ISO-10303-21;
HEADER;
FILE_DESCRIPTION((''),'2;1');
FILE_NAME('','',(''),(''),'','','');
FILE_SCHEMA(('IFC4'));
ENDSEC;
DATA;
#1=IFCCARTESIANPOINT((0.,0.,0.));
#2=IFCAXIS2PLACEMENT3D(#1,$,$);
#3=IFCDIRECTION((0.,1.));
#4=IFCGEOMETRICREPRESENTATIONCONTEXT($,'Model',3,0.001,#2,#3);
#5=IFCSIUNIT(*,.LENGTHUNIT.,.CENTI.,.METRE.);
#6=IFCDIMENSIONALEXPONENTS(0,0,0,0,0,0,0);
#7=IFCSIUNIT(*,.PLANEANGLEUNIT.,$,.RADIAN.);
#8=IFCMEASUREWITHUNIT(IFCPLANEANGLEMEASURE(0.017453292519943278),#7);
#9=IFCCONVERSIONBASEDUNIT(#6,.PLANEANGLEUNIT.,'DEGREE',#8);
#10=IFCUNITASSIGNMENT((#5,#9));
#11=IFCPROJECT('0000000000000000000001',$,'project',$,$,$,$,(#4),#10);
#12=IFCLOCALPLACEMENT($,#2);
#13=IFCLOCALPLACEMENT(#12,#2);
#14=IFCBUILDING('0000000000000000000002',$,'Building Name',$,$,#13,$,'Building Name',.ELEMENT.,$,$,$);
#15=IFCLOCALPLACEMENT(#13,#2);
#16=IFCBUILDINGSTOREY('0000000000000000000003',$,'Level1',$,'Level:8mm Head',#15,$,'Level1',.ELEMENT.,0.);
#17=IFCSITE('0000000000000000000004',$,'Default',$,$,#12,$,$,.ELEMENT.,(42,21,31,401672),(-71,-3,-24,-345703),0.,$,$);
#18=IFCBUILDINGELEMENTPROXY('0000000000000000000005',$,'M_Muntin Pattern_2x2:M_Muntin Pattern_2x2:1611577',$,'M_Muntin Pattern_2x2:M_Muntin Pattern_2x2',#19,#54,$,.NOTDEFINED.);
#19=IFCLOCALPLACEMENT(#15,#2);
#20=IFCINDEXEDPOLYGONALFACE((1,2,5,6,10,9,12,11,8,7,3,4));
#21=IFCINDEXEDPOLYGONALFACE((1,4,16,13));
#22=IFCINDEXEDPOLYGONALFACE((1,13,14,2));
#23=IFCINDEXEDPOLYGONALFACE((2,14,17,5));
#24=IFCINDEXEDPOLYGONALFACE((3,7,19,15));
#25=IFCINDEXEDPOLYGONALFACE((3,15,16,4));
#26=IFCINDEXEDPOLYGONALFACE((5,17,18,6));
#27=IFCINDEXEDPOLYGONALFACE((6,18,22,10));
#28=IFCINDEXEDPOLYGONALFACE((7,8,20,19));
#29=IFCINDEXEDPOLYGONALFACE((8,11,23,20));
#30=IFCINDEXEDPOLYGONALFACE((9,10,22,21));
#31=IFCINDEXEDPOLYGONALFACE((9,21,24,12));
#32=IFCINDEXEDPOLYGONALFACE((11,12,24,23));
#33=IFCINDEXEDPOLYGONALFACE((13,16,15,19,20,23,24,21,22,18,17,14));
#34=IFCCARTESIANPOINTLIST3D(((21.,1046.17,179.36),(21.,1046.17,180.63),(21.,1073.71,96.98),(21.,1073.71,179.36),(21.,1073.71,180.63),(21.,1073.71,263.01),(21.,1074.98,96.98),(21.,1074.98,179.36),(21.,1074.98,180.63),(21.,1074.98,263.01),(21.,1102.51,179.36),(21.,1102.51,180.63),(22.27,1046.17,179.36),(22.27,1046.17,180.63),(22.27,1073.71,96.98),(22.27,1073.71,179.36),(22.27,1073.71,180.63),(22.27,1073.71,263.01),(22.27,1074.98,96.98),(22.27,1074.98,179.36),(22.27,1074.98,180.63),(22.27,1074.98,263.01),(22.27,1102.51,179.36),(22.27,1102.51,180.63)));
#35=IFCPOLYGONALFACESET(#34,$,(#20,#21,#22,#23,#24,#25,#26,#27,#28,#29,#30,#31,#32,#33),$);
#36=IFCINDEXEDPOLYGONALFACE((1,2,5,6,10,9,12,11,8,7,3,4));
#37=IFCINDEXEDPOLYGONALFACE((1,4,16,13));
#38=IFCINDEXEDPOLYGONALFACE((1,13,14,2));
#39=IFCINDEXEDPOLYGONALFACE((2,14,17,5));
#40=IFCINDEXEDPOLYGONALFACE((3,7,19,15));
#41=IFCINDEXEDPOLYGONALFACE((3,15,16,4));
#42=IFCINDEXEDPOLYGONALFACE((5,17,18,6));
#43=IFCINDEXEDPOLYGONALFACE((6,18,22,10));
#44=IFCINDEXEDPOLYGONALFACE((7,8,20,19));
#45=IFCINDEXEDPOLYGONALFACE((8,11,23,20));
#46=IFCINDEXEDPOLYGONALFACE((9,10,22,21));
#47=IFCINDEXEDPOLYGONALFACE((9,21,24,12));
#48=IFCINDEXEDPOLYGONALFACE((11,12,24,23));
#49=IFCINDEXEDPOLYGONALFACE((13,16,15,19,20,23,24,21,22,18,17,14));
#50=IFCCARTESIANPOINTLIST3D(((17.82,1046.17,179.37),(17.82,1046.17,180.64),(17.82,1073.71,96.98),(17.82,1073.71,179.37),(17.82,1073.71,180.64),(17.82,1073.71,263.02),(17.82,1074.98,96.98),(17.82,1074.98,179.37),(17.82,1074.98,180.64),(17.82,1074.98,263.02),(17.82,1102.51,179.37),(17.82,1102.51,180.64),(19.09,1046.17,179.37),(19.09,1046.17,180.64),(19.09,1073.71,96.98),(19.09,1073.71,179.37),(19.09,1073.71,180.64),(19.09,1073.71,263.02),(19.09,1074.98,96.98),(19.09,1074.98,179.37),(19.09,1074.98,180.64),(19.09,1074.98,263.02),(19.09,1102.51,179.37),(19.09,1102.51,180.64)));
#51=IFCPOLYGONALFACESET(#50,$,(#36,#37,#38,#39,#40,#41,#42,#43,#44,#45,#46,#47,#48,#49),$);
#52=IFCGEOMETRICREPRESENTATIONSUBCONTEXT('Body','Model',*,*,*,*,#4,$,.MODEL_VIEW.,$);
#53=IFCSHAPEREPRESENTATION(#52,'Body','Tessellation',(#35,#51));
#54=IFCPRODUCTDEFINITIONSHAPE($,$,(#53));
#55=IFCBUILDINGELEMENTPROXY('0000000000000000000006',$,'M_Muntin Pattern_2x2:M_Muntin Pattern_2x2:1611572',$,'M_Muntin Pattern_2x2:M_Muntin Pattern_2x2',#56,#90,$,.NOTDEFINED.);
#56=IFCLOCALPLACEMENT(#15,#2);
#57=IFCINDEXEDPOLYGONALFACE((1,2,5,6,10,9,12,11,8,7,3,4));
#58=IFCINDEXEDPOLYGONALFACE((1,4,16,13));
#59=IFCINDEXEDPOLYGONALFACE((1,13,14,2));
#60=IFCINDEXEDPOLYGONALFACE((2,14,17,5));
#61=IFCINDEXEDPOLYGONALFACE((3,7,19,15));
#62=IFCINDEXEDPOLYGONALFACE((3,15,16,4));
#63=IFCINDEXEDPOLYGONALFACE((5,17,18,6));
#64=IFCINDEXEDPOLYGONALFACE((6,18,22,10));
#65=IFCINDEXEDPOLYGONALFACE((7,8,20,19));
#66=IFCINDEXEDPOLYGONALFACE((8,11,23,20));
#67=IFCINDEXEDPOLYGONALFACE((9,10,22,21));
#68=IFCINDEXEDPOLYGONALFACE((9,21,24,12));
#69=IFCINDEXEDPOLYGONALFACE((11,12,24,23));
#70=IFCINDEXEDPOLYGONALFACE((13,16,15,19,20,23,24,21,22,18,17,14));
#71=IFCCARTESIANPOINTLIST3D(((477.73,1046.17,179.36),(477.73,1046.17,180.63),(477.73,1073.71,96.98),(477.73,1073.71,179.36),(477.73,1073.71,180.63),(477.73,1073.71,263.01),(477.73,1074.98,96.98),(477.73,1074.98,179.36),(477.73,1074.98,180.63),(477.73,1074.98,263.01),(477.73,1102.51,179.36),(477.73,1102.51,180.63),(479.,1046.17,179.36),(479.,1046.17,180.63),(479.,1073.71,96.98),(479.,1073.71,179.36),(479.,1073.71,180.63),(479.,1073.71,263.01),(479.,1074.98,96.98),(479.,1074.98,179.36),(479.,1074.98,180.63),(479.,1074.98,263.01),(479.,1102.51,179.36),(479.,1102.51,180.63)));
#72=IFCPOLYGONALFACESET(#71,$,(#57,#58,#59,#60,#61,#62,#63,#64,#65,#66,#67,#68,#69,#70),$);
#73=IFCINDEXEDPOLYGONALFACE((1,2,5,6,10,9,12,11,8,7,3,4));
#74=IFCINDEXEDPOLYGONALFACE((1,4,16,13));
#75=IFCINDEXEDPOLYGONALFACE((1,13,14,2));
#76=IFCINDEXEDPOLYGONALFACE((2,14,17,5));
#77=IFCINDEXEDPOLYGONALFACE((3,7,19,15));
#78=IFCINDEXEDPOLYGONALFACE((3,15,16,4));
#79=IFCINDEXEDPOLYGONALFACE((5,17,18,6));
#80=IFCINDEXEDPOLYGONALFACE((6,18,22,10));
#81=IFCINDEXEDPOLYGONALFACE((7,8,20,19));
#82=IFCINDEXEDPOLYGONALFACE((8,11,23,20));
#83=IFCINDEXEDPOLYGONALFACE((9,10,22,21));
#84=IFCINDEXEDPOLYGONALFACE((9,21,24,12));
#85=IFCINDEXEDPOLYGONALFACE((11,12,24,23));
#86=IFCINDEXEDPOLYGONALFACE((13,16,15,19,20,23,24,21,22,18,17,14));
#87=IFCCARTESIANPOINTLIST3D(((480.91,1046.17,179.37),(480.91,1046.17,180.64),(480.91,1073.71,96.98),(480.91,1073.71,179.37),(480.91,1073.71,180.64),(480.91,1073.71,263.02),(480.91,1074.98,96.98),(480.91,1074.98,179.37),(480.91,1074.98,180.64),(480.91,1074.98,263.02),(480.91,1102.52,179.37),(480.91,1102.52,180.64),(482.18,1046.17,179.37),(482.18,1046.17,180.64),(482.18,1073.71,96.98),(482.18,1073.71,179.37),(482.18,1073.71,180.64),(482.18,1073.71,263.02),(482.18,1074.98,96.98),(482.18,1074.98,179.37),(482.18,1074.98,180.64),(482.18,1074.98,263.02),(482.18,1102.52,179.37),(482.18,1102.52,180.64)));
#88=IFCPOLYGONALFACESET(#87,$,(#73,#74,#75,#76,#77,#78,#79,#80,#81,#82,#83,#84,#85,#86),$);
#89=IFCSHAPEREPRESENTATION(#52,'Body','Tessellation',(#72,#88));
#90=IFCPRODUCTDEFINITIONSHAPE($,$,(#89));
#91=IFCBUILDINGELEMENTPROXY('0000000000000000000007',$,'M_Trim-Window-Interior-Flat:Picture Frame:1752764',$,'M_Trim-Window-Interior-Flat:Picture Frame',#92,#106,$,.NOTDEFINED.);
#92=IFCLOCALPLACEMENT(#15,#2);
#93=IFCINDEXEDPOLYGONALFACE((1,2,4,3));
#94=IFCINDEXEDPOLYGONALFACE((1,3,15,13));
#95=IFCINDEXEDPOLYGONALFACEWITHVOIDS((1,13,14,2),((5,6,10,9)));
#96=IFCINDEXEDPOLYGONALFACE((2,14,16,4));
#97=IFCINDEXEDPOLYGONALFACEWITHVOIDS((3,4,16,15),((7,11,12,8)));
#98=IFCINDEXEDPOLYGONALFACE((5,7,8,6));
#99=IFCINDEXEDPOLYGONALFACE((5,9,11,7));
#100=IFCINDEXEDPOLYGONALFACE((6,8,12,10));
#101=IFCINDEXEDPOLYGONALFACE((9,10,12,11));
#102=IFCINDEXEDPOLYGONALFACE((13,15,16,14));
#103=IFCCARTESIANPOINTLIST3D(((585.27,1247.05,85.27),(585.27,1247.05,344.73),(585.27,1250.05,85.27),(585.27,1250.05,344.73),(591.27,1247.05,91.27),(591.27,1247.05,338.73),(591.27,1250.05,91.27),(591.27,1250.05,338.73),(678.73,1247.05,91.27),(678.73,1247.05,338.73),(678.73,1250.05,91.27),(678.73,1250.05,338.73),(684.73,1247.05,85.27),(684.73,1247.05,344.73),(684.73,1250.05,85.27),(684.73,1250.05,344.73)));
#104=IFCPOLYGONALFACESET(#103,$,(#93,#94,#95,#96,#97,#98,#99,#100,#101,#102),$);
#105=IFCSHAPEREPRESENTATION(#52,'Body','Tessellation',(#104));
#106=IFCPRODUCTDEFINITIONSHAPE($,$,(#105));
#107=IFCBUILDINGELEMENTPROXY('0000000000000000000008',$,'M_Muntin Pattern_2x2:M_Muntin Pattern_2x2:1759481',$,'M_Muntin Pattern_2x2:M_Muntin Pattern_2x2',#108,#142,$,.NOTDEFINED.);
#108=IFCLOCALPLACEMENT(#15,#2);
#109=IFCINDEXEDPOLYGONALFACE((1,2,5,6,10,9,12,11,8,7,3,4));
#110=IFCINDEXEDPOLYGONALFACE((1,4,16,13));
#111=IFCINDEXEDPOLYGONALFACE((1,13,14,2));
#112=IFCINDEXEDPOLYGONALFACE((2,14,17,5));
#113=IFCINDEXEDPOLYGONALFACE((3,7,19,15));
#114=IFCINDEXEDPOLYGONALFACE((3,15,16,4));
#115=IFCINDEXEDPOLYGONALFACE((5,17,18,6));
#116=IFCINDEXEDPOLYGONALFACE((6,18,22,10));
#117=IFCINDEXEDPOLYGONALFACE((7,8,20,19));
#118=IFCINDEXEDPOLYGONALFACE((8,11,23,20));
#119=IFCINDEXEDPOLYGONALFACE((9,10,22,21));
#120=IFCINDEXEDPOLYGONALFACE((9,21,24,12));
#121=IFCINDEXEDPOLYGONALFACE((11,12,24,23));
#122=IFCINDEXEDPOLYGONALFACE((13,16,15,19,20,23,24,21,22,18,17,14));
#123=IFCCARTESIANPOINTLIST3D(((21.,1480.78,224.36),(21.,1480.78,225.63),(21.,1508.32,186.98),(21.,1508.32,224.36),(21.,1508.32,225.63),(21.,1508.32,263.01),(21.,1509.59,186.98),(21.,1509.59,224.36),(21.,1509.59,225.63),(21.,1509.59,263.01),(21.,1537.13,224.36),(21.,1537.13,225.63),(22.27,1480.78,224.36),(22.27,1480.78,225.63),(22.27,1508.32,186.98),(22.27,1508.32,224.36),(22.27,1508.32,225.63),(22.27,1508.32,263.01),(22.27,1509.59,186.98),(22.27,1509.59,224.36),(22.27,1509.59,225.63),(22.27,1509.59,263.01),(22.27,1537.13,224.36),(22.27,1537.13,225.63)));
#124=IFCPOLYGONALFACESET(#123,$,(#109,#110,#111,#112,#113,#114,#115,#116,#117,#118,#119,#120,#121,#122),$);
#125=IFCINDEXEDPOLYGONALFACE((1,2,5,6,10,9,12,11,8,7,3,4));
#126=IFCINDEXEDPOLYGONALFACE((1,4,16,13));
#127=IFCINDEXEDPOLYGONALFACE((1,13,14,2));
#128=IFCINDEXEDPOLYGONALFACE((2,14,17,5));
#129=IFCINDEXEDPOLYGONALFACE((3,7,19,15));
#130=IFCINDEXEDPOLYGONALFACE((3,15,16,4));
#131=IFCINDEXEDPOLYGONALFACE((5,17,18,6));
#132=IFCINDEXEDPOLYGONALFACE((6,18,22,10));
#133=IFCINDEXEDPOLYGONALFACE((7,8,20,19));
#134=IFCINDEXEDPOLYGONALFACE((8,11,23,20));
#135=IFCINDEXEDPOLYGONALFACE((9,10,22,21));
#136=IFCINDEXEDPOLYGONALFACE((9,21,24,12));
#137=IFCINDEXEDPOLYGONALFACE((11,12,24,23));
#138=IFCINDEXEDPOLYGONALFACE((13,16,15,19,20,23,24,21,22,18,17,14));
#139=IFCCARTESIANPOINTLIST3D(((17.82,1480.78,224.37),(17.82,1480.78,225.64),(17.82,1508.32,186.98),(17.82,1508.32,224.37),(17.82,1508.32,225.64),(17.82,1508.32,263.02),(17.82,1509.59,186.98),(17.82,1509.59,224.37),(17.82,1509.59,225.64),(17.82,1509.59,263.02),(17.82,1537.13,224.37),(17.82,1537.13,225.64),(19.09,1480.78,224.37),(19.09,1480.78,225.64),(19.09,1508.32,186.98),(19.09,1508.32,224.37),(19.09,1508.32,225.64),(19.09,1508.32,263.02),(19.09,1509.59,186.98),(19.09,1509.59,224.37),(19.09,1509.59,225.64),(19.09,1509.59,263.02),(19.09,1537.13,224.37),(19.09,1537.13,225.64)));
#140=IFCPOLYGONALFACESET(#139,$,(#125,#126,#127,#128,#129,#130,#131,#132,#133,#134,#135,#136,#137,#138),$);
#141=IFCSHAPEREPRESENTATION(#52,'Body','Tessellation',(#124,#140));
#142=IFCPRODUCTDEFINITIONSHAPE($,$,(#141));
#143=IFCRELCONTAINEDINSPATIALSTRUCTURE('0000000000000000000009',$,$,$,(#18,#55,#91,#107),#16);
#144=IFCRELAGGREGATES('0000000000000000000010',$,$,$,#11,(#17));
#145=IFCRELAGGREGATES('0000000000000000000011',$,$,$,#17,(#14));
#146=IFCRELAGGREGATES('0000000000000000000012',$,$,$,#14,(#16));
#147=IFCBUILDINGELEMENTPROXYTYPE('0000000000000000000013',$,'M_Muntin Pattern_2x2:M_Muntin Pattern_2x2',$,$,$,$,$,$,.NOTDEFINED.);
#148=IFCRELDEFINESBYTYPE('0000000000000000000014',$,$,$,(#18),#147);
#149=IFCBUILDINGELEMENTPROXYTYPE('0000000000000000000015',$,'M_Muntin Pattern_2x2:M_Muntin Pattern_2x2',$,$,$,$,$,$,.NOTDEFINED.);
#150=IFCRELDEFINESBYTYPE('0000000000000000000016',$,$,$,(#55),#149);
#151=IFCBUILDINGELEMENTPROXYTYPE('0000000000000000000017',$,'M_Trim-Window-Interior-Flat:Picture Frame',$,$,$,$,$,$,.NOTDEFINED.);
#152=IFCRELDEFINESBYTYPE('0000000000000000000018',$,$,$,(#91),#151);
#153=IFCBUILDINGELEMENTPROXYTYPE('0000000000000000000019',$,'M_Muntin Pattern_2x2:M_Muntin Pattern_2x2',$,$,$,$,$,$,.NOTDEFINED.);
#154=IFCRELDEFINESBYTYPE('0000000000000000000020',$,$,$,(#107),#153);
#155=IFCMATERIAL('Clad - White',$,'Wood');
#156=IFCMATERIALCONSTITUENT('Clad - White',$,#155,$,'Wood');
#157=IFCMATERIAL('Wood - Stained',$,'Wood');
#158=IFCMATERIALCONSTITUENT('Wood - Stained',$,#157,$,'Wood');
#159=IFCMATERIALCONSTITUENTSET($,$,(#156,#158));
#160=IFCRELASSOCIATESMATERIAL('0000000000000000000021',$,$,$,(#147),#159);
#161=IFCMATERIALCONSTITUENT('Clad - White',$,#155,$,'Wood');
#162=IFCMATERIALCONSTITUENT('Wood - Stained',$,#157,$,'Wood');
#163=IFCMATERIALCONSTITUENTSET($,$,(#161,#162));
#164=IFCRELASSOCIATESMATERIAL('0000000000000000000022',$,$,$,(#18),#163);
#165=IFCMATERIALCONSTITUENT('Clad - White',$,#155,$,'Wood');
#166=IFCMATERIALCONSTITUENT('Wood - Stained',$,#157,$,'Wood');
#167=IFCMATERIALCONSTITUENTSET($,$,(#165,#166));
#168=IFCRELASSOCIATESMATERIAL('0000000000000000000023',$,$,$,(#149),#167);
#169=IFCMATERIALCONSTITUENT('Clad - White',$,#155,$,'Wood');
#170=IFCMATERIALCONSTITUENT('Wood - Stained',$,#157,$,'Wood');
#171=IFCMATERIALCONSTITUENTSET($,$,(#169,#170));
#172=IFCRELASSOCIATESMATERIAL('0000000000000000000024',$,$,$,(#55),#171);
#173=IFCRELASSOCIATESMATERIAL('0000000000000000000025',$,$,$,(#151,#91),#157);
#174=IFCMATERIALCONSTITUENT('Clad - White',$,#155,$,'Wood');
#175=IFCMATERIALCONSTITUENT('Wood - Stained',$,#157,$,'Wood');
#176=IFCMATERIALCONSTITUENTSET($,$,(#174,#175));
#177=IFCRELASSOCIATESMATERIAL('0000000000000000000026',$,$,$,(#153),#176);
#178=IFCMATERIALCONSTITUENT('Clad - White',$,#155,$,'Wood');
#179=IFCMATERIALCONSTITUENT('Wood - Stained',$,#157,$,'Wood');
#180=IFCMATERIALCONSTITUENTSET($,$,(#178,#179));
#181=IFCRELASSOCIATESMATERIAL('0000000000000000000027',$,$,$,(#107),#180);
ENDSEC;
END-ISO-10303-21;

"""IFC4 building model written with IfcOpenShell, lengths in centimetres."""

from ifc_helpers import new_model, entity, si_unit, converted_unit, direction, frame, origin, place, context, subcontext, project, spatial, indexed_curve, outline, extrude, source, transform, mapped, material, constituent, constituent_set, type_object, type_shapes, element, save


model = new_model("IFC4")

# Units and contexts
model_context = context("Model", 3, precision=0.001, world=origin(), true_north=direction((0.0, 1.0)))
body_context = subcontext(model_context, "Body", "Model", "MODEL_VIEW")
ifc_project = project(units=[si_unit("LENGTHUNIT", "METRE", prefix="CENTI"), converted_unit("PLANEANGLEUNIT", "DEGREE", entity("IfcPlaneAngleMeasure", 0.017453292519943278), si_unit("PLANEANGLEUNIT", "RADIAN"), dimensions=[0, 0, 0, 0, 0, 0, 0])], contexts=[model_context])

# Site, building, storey
site_placement = place(None, origin())
site = spatial("IfcSite", under=ifc_project, at=site_placement, Name="Default", CompositionType="ELEMENT", RefLatitude=(42, 21, 31, 401672), RefLongitude=(-71, -3, -24, -345703), RefElevation=0.0)
building_placement = place(site_placement, origin())
building = spatial("IfcBuilding", under=site, at=building_placement, Name="Building Name", LongName="Building Name", CompositionType="ELEMENT")
storey_placement = place(building_placement, origin())
storey = spatial("IfcBuildingStorey", under=building, at=storey_placement, Name="Level1", ObjectType="Level:8mm Head", LongName="Level1", CompositionType="ELEMENT", Elevation=0.0)

# Building element proxies
ifc_material_1 = material(Name="Clad - White", Category="Wood")
ifc_constituent_1 = constituent(ifc_material_1, Name="Clad - White", Category="Wood")
ifc_material_2 = material(Name="Wood - Stained", Category="Wood")
ifc_constituent_2 = constituent(ifc_material_2, Name="Wood - Stained", Category="Wood")
ifc_constituent_set_1 = constituent_set(constituents=[ifc_constituent_1, ifc_constituent_2])
ifc_constituent_3 = constituent(ifc_material_1, Name="Clad - White", Category="Wood")
ifc_constituent_4 = constituent(ifc_material_2, Name="Wood - Stained", Category="Wood")
ifc_constituent_set_2 = constituent_set(constituents=[ifc_constituent_3, ifc_constituent_4])
building_element_proxy_type_1 = type_object("IfcBuildingElementProxyType", Name="M_Muntin Pattern_2x2:M_Muntin Pattern_2x2", PredefinedType="NOTDEFINED", material=ifc_constituent_set_2)
shared_shape_1 = source(origin(), body_context, "Body", "SweptSolid", [
    extrude(outline(indexed_curve([(0.64, -0.64), (83.01, -0.64), (83.01, 0.63), (0.64, 0.63), (0.64, 28.17), (-0.63, 28.17), (-0.63, 0.63), (-83.02, 0.63), (-83.02, -0.64), (-0.63, -0.64), (-0.63, -28.17), (0.64, -28.17), (0.64, -0.64)], self_intersect=False)), frame((0.0, 0.95, 83.01), z_axis=(0.0, 1.0, 0.0), x_axis=(0.0, 0.0, 1.0)), (0.0, 0.0, 1.0), 1.27),
    extrude(outline(indexed_curve([(0.64, -0.64), (83.02, -0.64), (83.02, 0.63), (0.64, 0.63), (0.64, 28.17), (-0.63, 28.17), (-0.63, 0.63), (-83.02, 0.63), (-83.02, -0.64), (-0.63, -0.64), (-0.63, -28.17), (0.64, -28.17), (0.64, -0.64)], self_intersect=False)), frame((0.0, -2.22, 83.02), z_axis=(0.0, 1.0, 0.0), x_axis=(0.0, 0.0, 1.0)), (0.0, 0.0, 1.0), 1.27),
])
type_shapes(building_element_proxy_type_1, [shared_shape_1])
proxy_1_placement = place(storey_placement, frame((20.05, 1074.34, 96.98), z_axis=(0.0, 0.0, 1.0), x_axis=(0.0, -1.0, 0.0)))
element("IfcBuildingElementProxy", 1, at=proxy_1_placement, inside=storey, type_object=building_element_proxy_type_1, material=ifc_constituent_set_1, Name="M_Muntin Pattern_2x2:M_Muntin Pattern_2x2:1611577", ObjectType="M_Muntin Pattern_2x2:M_Muntin Pattern_2x2", PredefinedType="NOTDEFINED", context=body_context, shape_type="MappedRepresentation", body=[
    mapped(shared_shape_1, transform((0.0, 0.0, 0.0), scale=1.0)),
])
ifc_constituent_5 = constituent(ifc_material_1, Name="Clad - White", Category="Wood")
ifc_constituent_6 = constituent(ifc_material_2, Name="Wood - Stained", Category="Wood")
ifc_constituent_set_3 = constituent_set(constituents=[ifc_constituent_5, ifc_constituent_6])
ifc_constituent_7 = constituent(ifc_material_1, Name="Clad - White", Category="Wood")
ifc_constituent_8 = constituent(ifc_material_2, Name="Wood - Stained", Category="Wood")
ifc_constituent_set_4 = constituent_set(constituents=[ifc_constituent_7, ifc_constituent_8])
building_element_proxy_type_2 = type_object("IfcBuildingElementProxyType", Name="M_Muntin Pattern_2x2:M_Muntin Pattern_2x2", PredefinedType="NOTDEFINED", material=ifc_constituent_set_4)
shared_shape_2 = source(origin(), body_context, "Body", "SweptSolid", [
    extrude(outline(indexed_curve([(0.64, -0.64), (83.01, -0.64), (83.01, 0.63), (0.64, 0.63), (0.64, 28.17), (-0.63, 28.17), (-0.63, 0.63), (-83.02, 0.63), (-83.02, -0.64), (-0.63, -0.64), (-0.63, -28.17), (0.64, -28.17), (0.64, -0.64)], self_intersect=False)), frame((0.0, -2.22, 83.01), z_axis=(0.0, 1.0, 0.0), x_axis=(0.0, 0.0, 1.0)), (0.0, 0.0, 1.0), 1.27),
    extrude(outline(indexed_curve([(0.64, -0.64), (83.02, -0.64), (83.02, 0.63), (0.64, 0.63), (0.64, 28.17), (-0.63, 28.17), (-0.63, 0.63), (-83.02, 0.63), (-83.02, -0.64), (-0.63, -0.64), (-0.63, -28.17), (0.64, -28.17), (0.64, -0.64)], self_intersect=False)), frame((0.0, 0.95, 83.02), z_axis=(0.0, 1.0, 0.0), x_axis=(0.0, 0.0, 1.0)), (0.0, 0.0, 1.0), 1.27),
])
type_shapes(building_element_proxy_type_2, [shared_shape_2])
proxy_2_placement = place(storey_placement, frame((479.95, 1074.34, 96.98), z_axis=(0.0, 0.0, 1.0), x_axis=(0.0, -1.0, 0.0)))
element("IfcBuildingElementProxy", 2, at=proxy_2_placement, inside=storey, type_object=building_element_proxy_type_2, material=ifc_constituent_set_3, Name="M_Muntin Pattern_2x2:M_Muntin Pattern_2x2:1611572", ObjectType="M_Muntin Pattern_2x2:M_Muntin Pattern_2x2", PredefinedType="NOTDEFINED", context=body_context, shape_type="MappedRepresentation", body=[
    mapped(shared_shape_2, transform((0.0, 0.0, 0.0), scale=1.0)),
])
building_element_proxy_type_3 = type_object("IfcBuildingElementProxyType", Name="M_Trim-Window-Interior-Flat:Picture Frame", PredefinedType="NOTDEFINED", material=ifc_material_2)
shared_shape_3 = source(origin(), body_context, "Body", "SweptSolid", [
    extrude(outline(indexed_curve([(-49.73, -129.73), (49.73, -129.73), (49.73, 129.73), (-49.73, 129.73), (-49.73, -129.73)], self_intersect=False), holes=[indexed_curve([(-43.73, -123.73), (-43.73, 123.73), (43.73, 123.73), (43.73, -123.73), (-43.73, -123.73)], self_intersect=False)]), frame((0.0, -125.0, 0.0), z_axis=(0.0, 0.0, 1.0), x_axis=(-1.0, 0.0, 0.0)), (0.0, 0.0, 1.0), 3.0),
])
type_shapes(building_element_proxy_type_3, [shared_shape_3])
proxy_3_placement = place(storey_placement, frame((635.0, 1250.05, 340.0), z_axis=(0.0, -1.0, 0.0), x_axis=(1.0, 0.0, 0.0)))
element("IfcBuildingElementProxy", 3, at=proxy_3_placement, inside=storey, type_object=building_element_proxy_type_3, material=ifc_material_2, Name="M_Trim-Window-Interior-Flat:Picture Frame:1752764", ObjectType="M_Trim-Window-Interior-Flat:Picture Frame", PredefinedType="NOTDEFINED", context=body_context, shape_type="MappedRepresentation", body=[
    mapped(shared_shape_3, transform((0.0, 0.0, 0.0), scale=1.0)),
])
ifc_constituent_9 = constituent(ifc_material_1, Name="Clad - White", Category="Wood")
ifc_constituent_10 = constituent(ifc_material_2, Name="Wood - Stained", Category="Wood")
ifc_constituent_set_5 = constituent_set(constituents=[ifc_constituent_9, ifc_constituent_10])
ifc_constituent_11 = constituent(ifc_material_1, Name="Clad - White", Category="Wood")
ifc_constituent_12 = constituent(ifc_material_2, Name="Wood - Stained", Category="Wood")
ifc_constituent_set_6 = constituent_set(constituents=[ifc_constituent_11, ifc_constituent_12])
building_element_proxy_type_4 = type_object("IfcBuildingElementProxyType", Name="M_Muntin Pattern_2x2:M_Muntin Pattern_2x2", PredefinedType="NOTDEFINED", material=ifc_constituent_set_6)
shared_shape_4 = source(origin(), body_context, "Body", "SweptSolid", [
    extrude(outline(indexed_curve([(0.64, -0.64), (38.01, -0.64), (38.01, 0.63), (0.64, 0.63), (0.64, 28.17), (-0.63, 28.17), (-0.63, 0.63), (-38.02, 0.63), (-38.02, -0.64), (-0.63, -0.64), (-0.63, -28.17), (0.64, -28.17), (0.64, -0.64)], self_intersect=False)), frame((0.0, -2.22, 38.01), z_axis=(0.0, 1.0, 0.0), x_axis=(0.0, 0.0, 1.0)), (0.0, 0.0, 1.0), 1.27),
    extrude(outline(indexed_curve([(0.64, -0.64), (38.02, -0.64), (38.02, 0.63), (0.64, 0.63), (0.64, 28.17), (-0.63, 28.17), (-0.63, 0.63), (-38.02, 0.63), (-38.02, -0.64), (-0.63, -0.64), (-0.63, -28.17), (0.64, -28.17), (0.64, -0.64)], self_intersect=False)), frame((0.0, 0.95, 38.02), z_axis=(0.0, 1.0, 0.0), x_axis=(0.0, 0.0, 1.0)), (0.0, 0.0, 1.0), 1.27),
])
type_shapes(building_element_proxy_type_4, [shared_shape_4])
proxy_4_placement = place(storey_placement, frame((20.05, 1508.96, 186.98), z_axis=(0.0, 0.0, 1.0), x_axis=(0.0, 1.0, 0.0)))
element("IfcBuildingElementProxy", 4, at=proxy_4_placement, inside=storey, type_object=building_element_proxy_type_4, material=ifc_constituent_set_5, Name="M_Muntin Pattern_2x2:M_Muntin Pattern_2x2:1759481", ObjectType="M_Muntin Pattern_2x2:M_Muntin Pattern_2x2", PredefinedType="NOTDEFINED", context=body_context, shape_type="MappedRepresentation", body=[
    mapped(shared_shape_4, transform((0.0, 0.0, 0.0), scale=1.0)),
])

save(model, "model.ifc")
